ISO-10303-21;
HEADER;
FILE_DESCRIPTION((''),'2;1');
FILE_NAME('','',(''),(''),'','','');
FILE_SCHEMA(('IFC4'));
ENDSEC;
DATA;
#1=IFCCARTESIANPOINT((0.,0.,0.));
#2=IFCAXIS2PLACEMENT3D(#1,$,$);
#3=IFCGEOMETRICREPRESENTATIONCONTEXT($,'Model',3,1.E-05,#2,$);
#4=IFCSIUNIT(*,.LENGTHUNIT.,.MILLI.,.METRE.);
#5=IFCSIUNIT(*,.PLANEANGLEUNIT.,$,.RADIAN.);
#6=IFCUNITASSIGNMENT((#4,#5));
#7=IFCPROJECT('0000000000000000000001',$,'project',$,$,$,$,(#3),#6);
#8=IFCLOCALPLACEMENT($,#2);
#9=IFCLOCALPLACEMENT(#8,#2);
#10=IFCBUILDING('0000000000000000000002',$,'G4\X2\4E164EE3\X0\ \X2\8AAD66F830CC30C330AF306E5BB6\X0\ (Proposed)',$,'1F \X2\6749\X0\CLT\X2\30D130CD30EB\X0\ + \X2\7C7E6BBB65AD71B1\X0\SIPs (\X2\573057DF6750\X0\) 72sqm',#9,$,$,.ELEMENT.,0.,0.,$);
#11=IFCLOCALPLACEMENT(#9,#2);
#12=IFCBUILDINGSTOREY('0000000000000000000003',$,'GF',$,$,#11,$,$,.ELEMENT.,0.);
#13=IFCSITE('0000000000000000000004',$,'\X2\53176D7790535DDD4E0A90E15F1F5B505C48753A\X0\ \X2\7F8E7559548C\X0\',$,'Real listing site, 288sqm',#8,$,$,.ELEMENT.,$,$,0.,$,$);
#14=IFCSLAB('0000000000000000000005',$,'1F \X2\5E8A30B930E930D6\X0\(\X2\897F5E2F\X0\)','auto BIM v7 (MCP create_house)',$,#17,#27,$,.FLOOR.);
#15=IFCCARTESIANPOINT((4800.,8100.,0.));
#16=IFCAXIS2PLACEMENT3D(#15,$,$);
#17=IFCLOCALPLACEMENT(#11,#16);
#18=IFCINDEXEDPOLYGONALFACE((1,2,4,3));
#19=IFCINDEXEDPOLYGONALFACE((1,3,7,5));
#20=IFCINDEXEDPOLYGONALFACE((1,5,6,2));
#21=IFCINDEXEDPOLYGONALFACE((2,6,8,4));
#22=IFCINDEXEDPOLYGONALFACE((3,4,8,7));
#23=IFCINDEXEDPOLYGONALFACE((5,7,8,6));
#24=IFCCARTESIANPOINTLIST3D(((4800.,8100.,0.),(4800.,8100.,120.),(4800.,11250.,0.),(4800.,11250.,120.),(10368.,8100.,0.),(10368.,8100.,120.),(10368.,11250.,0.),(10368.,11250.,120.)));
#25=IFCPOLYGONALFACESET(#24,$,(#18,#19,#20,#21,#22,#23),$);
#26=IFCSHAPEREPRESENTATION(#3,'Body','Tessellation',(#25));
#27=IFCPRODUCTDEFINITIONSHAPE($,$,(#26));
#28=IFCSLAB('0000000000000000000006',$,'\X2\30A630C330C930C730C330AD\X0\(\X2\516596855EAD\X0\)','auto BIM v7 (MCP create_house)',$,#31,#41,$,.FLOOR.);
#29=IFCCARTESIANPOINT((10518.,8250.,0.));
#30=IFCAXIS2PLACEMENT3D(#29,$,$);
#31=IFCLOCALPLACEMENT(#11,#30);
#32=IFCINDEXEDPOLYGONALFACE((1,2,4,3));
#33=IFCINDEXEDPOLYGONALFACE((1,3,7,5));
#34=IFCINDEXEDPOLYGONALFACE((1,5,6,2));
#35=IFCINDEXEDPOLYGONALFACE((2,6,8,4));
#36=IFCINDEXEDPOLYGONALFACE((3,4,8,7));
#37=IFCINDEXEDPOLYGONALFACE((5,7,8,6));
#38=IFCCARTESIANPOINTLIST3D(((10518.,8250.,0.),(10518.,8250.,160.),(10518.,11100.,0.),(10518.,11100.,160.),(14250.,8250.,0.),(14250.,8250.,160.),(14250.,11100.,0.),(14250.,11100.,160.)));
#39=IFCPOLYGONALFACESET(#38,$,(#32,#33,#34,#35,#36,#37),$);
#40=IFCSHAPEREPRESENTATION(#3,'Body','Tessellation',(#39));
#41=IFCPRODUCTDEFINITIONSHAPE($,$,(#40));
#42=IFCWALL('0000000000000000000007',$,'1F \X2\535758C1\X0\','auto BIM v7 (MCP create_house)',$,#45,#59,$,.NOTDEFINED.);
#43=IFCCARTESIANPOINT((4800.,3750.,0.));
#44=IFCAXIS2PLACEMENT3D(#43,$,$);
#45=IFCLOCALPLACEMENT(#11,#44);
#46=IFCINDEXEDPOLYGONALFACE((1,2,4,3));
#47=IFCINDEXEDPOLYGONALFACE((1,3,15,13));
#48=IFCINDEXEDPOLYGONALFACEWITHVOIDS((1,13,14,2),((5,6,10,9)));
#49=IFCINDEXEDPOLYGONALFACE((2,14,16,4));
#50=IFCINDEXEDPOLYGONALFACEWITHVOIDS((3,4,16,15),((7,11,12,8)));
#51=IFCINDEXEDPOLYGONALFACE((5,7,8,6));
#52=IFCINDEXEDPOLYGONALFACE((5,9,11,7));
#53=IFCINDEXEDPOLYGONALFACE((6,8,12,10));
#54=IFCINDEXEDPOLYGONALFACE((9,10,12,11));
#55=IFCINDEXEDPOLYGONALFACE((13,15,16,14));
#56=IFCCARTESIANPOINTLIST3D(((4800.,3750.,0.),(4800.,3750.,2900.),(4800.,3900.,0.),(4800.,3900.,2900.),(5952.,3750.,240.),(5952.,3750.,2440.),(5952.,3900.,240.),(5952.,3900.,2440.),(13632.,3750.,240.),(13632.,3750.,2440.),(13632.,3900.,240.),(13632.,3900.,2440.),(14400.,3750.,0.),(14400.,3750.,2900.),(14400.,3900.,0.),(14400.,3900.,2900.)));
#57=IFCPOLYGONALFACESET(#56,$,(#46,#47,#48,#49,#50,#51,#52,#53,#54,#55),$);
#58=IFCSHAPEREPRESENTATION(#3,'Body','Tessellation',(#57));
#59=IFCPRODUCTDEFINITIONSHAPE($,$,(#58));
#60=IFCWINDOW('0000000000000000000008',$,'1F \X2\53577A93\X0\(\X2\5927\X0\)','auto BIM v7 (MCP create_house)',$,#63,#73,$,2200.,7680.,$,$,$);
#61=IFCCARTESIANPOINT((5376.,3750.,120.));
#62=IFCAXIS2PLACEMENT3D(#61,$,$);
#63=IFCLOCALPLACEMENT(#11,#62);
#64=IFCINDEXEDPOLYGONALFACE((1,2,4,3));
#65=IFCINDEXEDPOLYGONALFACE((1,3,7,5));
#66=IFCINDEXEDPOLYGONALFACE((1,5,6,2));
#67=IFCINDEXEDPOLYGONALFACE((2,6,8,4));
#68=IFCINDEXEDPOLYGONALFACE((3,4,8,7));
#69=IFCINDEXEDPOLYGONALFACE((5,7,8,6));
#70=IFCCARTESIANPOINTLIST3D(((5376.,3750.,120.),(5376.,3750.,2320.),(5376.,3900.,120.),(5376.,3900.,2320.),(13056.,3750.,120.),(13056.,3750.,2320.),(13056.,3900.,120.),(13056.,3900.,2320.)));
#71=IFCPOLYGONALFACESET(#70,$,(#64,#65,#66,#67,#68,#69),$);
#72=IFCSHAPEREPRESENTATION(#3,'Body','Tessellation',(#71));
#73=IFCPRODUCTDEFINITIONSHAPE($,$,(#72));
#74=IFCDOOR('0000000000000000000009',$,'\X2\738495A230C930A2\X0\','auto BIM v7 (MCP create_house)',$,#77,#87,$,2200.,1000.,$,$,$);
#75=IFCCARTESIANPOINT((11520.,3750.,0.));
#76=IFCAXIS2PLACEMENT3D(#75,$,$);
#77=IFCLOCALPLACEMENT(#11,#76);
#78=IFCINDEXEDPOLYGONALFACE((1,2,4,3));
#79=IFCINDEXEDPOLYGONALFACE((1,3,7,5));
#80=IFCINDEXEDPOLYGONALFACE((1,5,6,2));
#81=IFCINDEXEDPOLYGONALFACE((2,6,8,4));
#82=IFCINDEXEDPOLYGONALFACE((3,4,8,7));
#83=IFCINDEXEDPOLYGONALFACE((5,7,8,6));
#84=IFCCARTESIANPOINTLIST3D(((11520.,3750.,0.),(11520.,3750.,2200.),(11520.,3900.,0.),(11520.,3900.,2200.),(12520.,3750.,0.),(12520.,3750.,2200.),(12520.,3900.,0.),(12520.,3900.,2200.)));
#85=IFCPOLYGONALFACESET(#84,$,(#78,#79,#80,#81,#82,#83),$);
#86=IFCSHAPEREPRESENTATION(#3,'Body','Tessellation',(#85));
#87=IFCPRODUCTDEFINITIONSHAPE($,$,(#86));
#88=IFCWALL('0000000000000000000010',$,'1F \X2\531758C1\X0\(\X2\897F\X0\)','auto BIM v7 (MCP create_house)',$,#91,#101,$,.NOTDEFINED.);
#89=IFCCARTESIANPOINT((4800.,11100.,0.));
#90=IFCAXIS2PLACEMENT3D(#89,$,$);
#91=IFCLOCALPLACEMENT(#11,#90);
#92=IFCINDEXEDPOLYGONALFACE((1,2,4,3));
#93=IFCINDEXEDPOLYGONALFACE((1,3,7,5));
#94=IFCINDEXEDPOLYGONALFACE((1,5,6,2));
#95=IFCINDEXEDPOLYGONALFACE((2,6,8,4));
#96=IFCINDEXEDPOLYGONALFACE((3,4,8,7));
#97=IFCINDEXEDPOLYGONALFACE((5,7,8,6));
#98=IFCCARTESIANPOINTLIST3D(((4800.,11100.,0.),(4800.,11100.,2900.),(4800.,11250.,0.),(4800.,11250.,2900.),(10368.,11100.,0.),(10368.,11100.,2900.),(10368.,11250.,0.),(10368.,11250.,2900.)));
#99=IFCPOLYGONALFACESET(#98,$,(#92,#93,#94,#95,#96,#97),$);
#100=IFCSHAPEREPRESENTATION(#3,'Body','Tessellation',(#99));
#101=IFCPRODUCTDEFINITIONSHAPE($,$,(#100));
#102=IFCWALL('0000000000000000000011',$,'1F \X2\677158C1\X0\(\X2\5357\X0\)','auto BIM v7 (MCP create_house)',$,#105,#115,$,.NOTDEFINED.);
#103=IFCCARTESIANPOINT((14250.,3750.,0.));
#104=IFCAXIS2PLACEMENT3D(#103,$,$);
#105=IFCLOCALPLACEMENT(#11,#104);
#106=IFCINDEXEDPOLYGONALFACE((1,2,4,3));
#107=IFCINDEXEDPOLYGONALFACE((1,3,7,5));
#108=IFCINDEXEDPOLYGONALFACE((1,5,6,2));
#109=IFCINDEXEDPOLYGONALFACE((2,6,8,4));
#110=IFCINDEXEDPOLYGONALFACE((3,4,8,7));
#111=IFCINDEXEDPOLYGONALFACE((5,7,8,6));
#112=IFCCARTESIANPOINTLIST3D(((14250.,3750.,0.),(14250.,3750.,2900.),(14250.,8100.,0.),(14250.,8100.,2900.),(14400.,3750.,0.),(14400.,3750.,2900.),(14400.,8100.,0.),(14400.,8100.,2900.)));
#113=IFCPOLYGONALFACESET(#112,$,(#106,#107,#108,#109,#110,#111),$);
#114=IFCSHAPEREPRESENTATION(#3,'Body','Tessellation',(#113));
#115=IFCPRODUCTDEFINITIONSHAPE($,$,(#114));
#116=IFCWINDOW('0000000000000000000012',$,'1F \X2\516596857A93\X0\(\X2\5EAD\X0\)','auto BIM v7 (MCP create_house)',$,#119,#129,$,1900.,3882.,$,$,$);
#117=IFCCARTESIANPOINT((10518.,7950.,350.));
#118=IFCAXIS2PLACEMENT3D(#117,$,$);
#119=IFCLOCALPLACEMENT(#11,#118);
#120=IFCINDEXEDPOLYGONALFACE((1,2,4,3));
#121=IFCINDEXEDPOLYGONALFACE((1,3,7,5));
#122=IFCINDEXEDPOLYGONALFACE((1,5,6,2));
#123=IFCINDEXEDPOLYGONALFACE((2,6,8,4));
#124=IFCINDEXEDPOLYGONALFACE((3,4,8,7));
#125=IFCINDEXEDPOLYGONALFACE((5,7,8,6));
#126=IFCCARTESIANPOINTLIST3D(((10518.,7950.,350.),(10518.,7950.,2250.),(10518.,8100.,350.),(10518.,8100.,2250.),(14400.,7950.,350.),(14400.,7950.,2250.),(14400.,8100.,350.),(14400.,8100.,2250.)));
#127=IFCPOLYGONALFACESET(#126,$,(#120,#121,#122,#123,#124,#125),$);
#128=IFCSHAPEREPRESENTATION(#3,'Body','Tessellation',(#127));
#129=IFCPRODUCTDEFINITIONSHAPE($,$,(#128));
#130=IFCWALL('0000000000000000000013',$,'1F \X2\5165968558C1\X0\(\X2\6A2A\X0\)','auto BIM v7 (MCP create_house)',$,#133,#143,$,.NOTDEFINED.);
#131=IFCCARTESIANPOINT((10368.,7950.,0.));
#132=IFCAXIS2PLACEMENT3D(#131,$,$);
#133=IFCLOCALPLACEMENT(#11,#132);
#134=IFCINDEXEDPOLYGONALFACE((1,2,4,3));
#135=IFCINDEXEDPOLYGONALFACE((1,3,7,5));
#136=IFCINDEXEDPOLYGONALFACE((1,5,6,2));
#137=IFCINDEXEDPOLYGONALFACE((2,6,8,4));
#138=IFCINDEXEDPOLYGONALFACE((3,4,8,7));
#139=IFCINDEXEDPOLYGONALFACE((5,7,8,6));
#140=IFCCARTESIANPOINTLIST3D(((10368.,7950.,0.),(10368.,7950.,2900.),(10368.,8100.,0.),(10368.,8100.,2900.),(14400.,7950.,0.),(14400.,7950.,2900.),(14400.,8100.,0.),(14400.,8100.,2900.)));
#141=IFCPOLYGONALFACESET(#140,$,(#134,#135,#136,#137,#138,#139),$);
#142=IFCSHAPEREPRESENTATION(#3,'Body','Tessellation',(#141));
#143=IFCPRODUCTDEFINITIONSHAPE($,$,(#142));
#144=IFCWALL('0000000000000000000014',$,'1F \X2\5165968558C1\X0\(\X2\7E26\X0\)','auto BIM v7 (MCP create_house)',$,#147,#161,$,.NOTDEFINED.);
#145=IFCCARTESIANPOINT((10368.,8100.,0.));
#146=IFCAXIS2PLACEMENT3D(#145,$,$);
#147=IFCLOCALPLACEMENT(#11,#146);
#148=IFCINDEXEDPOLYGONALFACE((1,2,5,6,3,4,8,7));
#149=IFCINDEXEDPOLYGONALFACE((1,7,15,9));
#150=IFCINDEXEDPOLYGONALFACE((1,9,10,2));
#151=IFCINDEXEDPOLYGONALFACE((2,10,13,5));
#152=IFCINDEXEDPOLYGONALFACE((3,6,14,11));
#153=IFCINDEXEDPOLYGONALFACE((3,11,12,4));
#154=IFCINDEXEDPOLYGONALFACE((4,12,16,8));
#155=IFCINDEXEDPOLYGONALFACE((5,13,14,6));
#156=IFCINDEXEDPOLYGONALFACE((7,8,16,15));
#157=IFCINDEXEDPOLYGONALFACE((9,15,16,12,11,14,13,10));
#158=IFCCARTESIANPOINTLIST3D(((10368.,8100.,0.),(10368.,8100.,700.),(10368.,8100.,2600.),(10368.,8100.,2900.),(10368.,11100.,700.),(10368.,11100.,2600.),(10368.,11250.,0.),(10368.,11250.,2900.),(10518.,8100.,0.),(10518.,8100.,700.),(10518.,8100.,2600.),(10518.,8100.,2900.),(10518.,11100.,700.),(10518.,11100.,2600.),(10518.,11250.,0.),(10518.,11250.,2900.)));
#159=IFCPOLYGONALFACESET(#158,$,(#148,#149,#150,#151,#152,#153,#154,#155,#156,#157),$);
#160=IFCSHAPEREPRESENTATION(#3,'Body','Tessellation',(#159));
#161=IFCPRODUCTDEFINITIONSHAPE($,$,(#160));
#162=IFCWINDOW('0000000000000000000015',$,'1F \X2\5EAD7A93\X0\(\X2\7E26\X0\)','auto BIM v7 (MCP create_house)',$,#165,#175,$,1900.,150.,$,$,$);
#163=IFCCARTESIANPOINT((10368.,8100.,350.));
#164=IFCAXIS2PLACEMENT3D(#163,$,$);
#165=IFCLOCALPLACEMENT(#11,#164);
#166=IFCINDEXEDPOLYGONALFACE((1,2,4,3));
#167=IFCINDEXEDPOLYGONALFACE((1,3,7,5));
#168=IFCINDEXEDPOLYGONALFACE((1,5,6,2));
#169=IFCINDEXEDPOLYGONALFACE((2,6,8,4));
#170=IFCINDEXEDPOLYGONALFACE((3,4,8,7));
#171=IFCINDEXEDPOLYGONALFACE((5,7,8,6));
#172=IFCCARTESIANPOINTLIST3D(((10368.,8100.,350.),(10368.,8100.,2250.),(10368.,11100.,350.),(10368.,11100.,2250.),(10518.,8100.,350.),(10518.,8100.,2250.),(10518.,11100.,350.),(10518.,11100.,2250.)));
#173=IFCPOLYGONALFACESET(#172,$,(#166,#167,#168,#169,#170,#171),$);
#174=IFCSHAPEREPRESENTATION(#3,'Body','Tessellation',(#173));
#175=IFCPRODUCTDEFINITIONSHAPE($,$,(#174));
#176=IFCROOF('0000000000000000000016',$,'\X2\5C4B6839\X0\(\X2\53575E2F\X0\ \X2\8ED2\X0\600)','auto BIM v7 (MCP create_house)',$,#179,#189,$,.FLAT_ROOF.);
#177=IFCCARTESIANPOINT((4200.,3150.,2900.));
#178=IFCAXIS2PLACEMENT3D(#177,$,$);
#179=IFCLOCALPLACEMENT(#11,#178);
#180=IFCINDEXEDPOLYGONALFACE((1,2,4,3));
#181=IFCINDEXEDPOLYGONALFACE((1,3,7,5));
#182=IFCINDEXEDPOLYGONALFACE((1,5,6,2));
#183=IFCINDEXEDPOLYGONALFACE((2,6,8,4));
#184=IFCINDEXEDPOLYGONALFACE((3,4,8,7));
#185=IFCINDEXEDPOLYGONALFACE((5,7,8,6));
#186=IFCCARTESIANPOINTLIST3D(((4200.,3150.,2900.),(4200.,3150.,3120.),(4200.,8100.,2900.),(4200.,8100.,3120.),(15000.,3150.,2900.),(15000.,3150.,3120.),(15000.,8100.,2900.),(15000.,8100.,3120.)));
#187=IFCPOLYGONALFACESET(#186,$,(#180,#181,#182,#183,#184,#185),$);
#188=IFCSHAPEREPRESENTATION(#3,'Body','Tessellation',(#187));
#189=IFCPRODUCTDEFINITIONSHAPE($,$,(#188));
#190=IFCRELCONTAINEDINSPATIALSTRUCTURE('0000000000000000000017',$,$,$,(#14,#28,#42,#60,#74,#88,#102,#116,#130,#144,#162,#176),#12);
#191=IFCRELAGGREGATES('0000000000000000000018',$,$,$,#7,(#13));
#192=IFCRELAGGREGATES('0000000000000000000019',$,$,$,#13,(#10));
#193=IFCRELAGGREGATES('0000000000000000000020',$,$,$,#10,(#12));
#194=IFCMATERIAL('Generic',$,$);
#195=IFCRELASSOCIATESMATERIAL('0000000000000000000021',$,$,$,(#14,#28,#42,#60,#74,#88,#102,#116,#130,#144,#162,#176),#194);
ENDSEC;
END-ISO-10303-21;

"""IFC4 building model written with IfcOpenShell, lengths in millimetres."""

from ifc_helpers import new_model, si_unit, frame, frame_2d, origin, place, context, project, spatial, rectangle, extrude, material, element, fill, save


model = new_model("IFC4")

# Units and contexts
model_context = context("Model", 3, precision=1e-05, world=origin())
ifc_project = project(units=[si_unit("LENGTHUNIT", "METRE", prefix="MILLI"), si_unit("PLANEANGLEUNIT", "RADIAN")], contexts=[model_context])

# Site, building, storey
site_placement = place(None, origin())
site = spatial("IfcSite", under=ifc_project, at=site_placement, Name="北海道川上郡弟子屈町 美留和", ObjectType="Real listing site, 288sqm", CompositionType="ELEMENT", RefElevation=0.0)
building_placement = place(site_placement, origin())
building = spatial("IfcBuilding", under=site, at=building_placement, Name="G4世代 読書ヌックの家 (Proposed)", ObjectType="1F 杉CLTパネル + 籾殻断熱SIPs (地域材) 72sqm", CompositionType="ELEMENT", ElevationOfRefHeight=0.0, ElevationOfTerrain=0.0)
storey_placement = place(building_placement, origin())
storey = spatial("IfcBuildingStorey", under=building, at=storey_placement, Name="GF", CompositionType="ELEMENT", Elevation=0.0)

# Slabs
ifc_material = material(Name="Generic")
slab_1_placement = place(storey_placement, frame((4800.0, 8100.0, 0.0)))
element("IfcSlab", 1, at=slab_1_placement, inside=storey, material=ifc_material, Name="1F 床スラブ(西帯)", Description="auto BIM v7 (MCP create_house)", PredefinedType="FLOOR", context=model_context, shape_type="SweptSolid", body=[
    extrude(rectangle(XDim=5568.0, YDim=3150.0, at=frame_2d((2784.0, 1575.0))), frame((4800.0, 8100.0, 0.0)), (0.0, 0.0, 1.0), 120.0),
])
slab_2_placement = place(storey_placement, frame((10518.0, 8250.0, 0.0)))
element("IfcSlab", 2, at=slab_2_placement, inside=storey, material=ifc_material, Name="ウッドデッキ(入隅庭)", Description="auto BIM v7 (MCP create_house)", PredefinedType="FLOOR", context=model_context, shape_type="SweptSolid", body=[
    extrude(rectangle(XDim=3732.0, YDim=2850.0, at=frame_2d((1866.0, 1425.0))), frame((10518.0, 8250.0, 0.0)), (0.0, 0.0, 1.0), 160.0),
])

# Wall, openings, window, door
wall_1_placement = place(storey_placement, frame((4800.0, 3750.0, 0.0)))
wall_1 = element("IfcWall", 3, at=wall_1_placement, inside=storey, material=ifc_material, Name="1F 南壁", Description="auto BIM v7 (MCP create_house)", PredefinedType="NOTDEFINED", context=model_context, shape_type="SweptSolid", body=[
    extrude(rectangle(XDim=9600.0, YDim=150.0, at=frame_2d((4800.0, 75.0))), frame((4800.0, 3750.0, 0.0)), (0.0, 0.0, 1.0), 2900.0),
])
opening_1_placement = place(storey_placement, frame((5376.0, 3750.0, 120.0)))
opening_1 = element("IfcOpeningElement", 4, at=opening_1_placement, cuts=wall_1, PredefinedType="NOTDEFINED", context=model_context, shape_type="SweptSolid", body=[
    extrude(rectangle(XDim=7680.0, YDim=150.0, at=frame_2d((3840.0, 75.0))), frame((5376.0, 3750.0, 120.0)), (0.0, 0.0, 1.0), 2200.0),
])
opening_2_placement = place(storey_placement, frame((11520.0, 3750.0, 0.0)))
opening_2 = element("IfcOpeningElement", 5, at=opening_2_placement, cuts=wall_1, PredefinedType="NOTDEFINED", context=model_context, shape_type="SweptSolid", body=[
    extrude(rectangle(XDim=1000.0, YDim=150.0, at=frame_2d((500.0, 75.0))), frame((11520.0, 3750.0, 0.0)), (0.0, 0.0, 1.0), 2200.0),
])
window_1_placement = place(storey_placement, frame((5376.0, 3750.0, 120.0)))
window_1 = element("IfcWindow", 6, at=window_1_placement, inside=storey, material=ifc_material, Name="1F 南窓(大)", Description="auto BIM v7 (MCP create_house)", OverallHeight=2200.0, OverallWidth=7680.0, context=model_context, shape_type="SweptSolid", body=[
    extrude(rectangle(XDim=7680.0, YDim=150.0, at=frame_2d((3840.0, 75.0))), frame((5376.0, 3750.0, 120.0)), (0.0, 0.0, 1.0), 2200.0),
])
fill(opening_1, window_1)
door_placement = place(storey_placement, frame((11520.0, 3750.0, 0.0)))
door = element("IfcDoor", 7, at=door_placement, inside=storey, material=ifc_material, Name="玄関ドア", Description="auto BIM v7 (MCP create_house)", OverallHeight=2200.0, OverallWidth=1000.0, context=model_context, shape_type="SweptSolid", body=[
    extrude(rectangle(XDim=1000.0, YDim=150.0, at=frame_2d((500.0, 75.0))), frame((11520.0, 3750.0, 0.0)), (0.0, 0.0, 1.0), 2200.0),
])
fill(opening_2, door)

# Wall
wall_2_placement = place(storey_placement, frame((4800.0, 11100.0, 0.0)))
element("IfcWall", 8, at=wall_2_placement, inside=storey, material=ifc_material, Name="1F 北壁(西)", Description="auto BIM v7 (MCP create_house)", PredefinedType="NOTDEFINED", context=model_context, shape_type="SweptSolid", body=[
    extrude(rectangle(XDim=5568.0, YDim=150.0, at=frame_2d((2784.0, 75.0))), frame((4800.0, 11100.0, 0.0)), (0.0, 0.0, 1.0), 2900.0),
])

# Wall, opening, window
wall_3_placement = place(storey_placement, frame((14250.0, 3750.0, 0.0)))
wall_3 = element("IfcWall", 9, at=wall_3_placement, inside=storey, material=ifc_material, Name="1F 東壁(南)", Description="auto BIM v7 (MCP create_house)", PredefinedType="NOTDEFINED", context=model_context, shape_type="SweptSolid", body=[
    extrude(rectangle(XDim=150.0, YDim=4350.0, at=frame_2d((75.0, 2175.0))), frame((14250.0, 3750.0, 0.0)), (0.0, 0.0, 1.0), 2900.0),
])
opening_3_placement = place(storey_placement, frame((10518.0, 7950.0, 350.0)))
opening_3 = element("IfcOpeningElement", 10, at=opening_3_placement, cuts=wall_3, PredefinedType="NOTDEFINED", context=model_context, shape_type="SweptSolid", body=[
    extrude(rectangle(XDim=3882.0, YDim=150.0, at=frame_2d((1941.0, 75.0))), frame((10518.0, 7950.0, 350.0)), (0.0, 0.0, 1.0), 1900.0),
])
window_2_placement = place(storey_placement, frame((10518.0, 7950.0, 350.0)))
window_2 = element("IfcWindow", 11, at=window_2_placement, inside=storey, material=ifc_material, Name="1F 入隅窓(庭)", Description="auto BIM v7 (MCP create_house)", OverallHeight=1900.0, OverallWidth=3882.0, context=model_context, shape_type="SweptSolid", body=[
    extrude(rectangle(XDim=3882.0, YDim=150.0, at=frame_2d((1941.0, 75.0))), frame((10518.0, 7950.0, 350.0)), (0.0, 0.0, 1.0), 1900.0),
])
fill(opening_3, window_2)

# Wall
wall_4_placement = place(storey_placement, frame((10368.0, 7950.0, 0.0)))
element("IfcWall", 12, at=wall_4_placement, inside=storey, material=ifc_material, Name="1F 入隅壁(横)", Description="auto BIM v7 (MCP create_house)", PredefinedType="NOTDEFINED", context=model_context, shape_type="SweptSolid", body=[
    extrude(rectangle(XDim=4032.0, YDim=150.0, at=frame_2d((2016.0, 75.0))), frame((10368.0, 7950.0, 0.0)), (0.0, 0.0, 1.0), 2900.0),
])

# Wall, opening, window
wall_5_placement = place(storey_placement, frame((10368.0, 8100.0, 0.0)))
wall_5 = element("IfcWall", 13, at=wall_5_placement, inside=storey, material=ifc_material, Name="1F 入隅壁(縦)", Description="auto BIM v7 (MCP create_house)", PredefinedType="NOTDEFINED", context=model_context, shape_type="SweptSolid", body=[
    extrude(rectangle(XDim=150.0, YDim=3150.0, at=frame_2d((75.0, 1575.0))), frame((10368.0, 8100.0, 0.0)), (0.0, 0.0, 1.0), 2900.0),
])
opening_4_placement = place(storey_placement, frame((10368.0, 8100.0, 350.0)))
opening_4 = element("IfcOpeningElement", 14, at=opening_4_placement, cuts=wall_5, PredefinedType="NOTDEFINED", context=model_context, shape_type="SweptSolid", body=[
    extrude(rectangle(XDim=150.0, YDim=3000.0, at=frame_2d((75.0, 1500.0))), frame((10368.0, 8100.0, 350.0)), (0.0, 0.0, 1.0), 1900.0),
])
window_3_placement = place(storey_placement, frame((10368.0, 8100.0, 350.0)))
window_3 = element("IfcWindow", 15, at=window_3_placement, inside=storey, material=ifc_material, Name="1F 庭窓(縦)", Description="auto BIM v7 (MCP create_house)", OverallHeight=1900.0, OverallWidth=150.0, context=model_context, shape_type="SweptSolid", body=[
    extrude(rectangle(XDim=150.0, YDim=3000.0, at=frame_2d((75.0, 1500.0))), frame((10368.0, 8100.0, 350.0)), (0.0, 0.0, 1.0), 1900.0),
])
fill(opening_4, window_3)

# Roof
roof_1_placement = place(storey_placement, frame((4200.0, 3150.0, 2900.0)))
element("IfcRoof", 16, at=roof_1_placement, inside=storey, material=ifc_material, Name="屋根(南帯 軒600)", Description="auto BIM v7 (MCP create_house)", PredefinedType="FLAT_ROOF", context=model_context, shape_type="SweptSolid", body=[
    extrude(rectangle(XDim=10800.0, YDim=4950.0, at=frame_2d((5400.0, 2475.0))), frame((4200.0, 3150.0, 2900.0)), (0.0, 0.0, 1.0), 220.0),
])

save(model, "model.ifc")
